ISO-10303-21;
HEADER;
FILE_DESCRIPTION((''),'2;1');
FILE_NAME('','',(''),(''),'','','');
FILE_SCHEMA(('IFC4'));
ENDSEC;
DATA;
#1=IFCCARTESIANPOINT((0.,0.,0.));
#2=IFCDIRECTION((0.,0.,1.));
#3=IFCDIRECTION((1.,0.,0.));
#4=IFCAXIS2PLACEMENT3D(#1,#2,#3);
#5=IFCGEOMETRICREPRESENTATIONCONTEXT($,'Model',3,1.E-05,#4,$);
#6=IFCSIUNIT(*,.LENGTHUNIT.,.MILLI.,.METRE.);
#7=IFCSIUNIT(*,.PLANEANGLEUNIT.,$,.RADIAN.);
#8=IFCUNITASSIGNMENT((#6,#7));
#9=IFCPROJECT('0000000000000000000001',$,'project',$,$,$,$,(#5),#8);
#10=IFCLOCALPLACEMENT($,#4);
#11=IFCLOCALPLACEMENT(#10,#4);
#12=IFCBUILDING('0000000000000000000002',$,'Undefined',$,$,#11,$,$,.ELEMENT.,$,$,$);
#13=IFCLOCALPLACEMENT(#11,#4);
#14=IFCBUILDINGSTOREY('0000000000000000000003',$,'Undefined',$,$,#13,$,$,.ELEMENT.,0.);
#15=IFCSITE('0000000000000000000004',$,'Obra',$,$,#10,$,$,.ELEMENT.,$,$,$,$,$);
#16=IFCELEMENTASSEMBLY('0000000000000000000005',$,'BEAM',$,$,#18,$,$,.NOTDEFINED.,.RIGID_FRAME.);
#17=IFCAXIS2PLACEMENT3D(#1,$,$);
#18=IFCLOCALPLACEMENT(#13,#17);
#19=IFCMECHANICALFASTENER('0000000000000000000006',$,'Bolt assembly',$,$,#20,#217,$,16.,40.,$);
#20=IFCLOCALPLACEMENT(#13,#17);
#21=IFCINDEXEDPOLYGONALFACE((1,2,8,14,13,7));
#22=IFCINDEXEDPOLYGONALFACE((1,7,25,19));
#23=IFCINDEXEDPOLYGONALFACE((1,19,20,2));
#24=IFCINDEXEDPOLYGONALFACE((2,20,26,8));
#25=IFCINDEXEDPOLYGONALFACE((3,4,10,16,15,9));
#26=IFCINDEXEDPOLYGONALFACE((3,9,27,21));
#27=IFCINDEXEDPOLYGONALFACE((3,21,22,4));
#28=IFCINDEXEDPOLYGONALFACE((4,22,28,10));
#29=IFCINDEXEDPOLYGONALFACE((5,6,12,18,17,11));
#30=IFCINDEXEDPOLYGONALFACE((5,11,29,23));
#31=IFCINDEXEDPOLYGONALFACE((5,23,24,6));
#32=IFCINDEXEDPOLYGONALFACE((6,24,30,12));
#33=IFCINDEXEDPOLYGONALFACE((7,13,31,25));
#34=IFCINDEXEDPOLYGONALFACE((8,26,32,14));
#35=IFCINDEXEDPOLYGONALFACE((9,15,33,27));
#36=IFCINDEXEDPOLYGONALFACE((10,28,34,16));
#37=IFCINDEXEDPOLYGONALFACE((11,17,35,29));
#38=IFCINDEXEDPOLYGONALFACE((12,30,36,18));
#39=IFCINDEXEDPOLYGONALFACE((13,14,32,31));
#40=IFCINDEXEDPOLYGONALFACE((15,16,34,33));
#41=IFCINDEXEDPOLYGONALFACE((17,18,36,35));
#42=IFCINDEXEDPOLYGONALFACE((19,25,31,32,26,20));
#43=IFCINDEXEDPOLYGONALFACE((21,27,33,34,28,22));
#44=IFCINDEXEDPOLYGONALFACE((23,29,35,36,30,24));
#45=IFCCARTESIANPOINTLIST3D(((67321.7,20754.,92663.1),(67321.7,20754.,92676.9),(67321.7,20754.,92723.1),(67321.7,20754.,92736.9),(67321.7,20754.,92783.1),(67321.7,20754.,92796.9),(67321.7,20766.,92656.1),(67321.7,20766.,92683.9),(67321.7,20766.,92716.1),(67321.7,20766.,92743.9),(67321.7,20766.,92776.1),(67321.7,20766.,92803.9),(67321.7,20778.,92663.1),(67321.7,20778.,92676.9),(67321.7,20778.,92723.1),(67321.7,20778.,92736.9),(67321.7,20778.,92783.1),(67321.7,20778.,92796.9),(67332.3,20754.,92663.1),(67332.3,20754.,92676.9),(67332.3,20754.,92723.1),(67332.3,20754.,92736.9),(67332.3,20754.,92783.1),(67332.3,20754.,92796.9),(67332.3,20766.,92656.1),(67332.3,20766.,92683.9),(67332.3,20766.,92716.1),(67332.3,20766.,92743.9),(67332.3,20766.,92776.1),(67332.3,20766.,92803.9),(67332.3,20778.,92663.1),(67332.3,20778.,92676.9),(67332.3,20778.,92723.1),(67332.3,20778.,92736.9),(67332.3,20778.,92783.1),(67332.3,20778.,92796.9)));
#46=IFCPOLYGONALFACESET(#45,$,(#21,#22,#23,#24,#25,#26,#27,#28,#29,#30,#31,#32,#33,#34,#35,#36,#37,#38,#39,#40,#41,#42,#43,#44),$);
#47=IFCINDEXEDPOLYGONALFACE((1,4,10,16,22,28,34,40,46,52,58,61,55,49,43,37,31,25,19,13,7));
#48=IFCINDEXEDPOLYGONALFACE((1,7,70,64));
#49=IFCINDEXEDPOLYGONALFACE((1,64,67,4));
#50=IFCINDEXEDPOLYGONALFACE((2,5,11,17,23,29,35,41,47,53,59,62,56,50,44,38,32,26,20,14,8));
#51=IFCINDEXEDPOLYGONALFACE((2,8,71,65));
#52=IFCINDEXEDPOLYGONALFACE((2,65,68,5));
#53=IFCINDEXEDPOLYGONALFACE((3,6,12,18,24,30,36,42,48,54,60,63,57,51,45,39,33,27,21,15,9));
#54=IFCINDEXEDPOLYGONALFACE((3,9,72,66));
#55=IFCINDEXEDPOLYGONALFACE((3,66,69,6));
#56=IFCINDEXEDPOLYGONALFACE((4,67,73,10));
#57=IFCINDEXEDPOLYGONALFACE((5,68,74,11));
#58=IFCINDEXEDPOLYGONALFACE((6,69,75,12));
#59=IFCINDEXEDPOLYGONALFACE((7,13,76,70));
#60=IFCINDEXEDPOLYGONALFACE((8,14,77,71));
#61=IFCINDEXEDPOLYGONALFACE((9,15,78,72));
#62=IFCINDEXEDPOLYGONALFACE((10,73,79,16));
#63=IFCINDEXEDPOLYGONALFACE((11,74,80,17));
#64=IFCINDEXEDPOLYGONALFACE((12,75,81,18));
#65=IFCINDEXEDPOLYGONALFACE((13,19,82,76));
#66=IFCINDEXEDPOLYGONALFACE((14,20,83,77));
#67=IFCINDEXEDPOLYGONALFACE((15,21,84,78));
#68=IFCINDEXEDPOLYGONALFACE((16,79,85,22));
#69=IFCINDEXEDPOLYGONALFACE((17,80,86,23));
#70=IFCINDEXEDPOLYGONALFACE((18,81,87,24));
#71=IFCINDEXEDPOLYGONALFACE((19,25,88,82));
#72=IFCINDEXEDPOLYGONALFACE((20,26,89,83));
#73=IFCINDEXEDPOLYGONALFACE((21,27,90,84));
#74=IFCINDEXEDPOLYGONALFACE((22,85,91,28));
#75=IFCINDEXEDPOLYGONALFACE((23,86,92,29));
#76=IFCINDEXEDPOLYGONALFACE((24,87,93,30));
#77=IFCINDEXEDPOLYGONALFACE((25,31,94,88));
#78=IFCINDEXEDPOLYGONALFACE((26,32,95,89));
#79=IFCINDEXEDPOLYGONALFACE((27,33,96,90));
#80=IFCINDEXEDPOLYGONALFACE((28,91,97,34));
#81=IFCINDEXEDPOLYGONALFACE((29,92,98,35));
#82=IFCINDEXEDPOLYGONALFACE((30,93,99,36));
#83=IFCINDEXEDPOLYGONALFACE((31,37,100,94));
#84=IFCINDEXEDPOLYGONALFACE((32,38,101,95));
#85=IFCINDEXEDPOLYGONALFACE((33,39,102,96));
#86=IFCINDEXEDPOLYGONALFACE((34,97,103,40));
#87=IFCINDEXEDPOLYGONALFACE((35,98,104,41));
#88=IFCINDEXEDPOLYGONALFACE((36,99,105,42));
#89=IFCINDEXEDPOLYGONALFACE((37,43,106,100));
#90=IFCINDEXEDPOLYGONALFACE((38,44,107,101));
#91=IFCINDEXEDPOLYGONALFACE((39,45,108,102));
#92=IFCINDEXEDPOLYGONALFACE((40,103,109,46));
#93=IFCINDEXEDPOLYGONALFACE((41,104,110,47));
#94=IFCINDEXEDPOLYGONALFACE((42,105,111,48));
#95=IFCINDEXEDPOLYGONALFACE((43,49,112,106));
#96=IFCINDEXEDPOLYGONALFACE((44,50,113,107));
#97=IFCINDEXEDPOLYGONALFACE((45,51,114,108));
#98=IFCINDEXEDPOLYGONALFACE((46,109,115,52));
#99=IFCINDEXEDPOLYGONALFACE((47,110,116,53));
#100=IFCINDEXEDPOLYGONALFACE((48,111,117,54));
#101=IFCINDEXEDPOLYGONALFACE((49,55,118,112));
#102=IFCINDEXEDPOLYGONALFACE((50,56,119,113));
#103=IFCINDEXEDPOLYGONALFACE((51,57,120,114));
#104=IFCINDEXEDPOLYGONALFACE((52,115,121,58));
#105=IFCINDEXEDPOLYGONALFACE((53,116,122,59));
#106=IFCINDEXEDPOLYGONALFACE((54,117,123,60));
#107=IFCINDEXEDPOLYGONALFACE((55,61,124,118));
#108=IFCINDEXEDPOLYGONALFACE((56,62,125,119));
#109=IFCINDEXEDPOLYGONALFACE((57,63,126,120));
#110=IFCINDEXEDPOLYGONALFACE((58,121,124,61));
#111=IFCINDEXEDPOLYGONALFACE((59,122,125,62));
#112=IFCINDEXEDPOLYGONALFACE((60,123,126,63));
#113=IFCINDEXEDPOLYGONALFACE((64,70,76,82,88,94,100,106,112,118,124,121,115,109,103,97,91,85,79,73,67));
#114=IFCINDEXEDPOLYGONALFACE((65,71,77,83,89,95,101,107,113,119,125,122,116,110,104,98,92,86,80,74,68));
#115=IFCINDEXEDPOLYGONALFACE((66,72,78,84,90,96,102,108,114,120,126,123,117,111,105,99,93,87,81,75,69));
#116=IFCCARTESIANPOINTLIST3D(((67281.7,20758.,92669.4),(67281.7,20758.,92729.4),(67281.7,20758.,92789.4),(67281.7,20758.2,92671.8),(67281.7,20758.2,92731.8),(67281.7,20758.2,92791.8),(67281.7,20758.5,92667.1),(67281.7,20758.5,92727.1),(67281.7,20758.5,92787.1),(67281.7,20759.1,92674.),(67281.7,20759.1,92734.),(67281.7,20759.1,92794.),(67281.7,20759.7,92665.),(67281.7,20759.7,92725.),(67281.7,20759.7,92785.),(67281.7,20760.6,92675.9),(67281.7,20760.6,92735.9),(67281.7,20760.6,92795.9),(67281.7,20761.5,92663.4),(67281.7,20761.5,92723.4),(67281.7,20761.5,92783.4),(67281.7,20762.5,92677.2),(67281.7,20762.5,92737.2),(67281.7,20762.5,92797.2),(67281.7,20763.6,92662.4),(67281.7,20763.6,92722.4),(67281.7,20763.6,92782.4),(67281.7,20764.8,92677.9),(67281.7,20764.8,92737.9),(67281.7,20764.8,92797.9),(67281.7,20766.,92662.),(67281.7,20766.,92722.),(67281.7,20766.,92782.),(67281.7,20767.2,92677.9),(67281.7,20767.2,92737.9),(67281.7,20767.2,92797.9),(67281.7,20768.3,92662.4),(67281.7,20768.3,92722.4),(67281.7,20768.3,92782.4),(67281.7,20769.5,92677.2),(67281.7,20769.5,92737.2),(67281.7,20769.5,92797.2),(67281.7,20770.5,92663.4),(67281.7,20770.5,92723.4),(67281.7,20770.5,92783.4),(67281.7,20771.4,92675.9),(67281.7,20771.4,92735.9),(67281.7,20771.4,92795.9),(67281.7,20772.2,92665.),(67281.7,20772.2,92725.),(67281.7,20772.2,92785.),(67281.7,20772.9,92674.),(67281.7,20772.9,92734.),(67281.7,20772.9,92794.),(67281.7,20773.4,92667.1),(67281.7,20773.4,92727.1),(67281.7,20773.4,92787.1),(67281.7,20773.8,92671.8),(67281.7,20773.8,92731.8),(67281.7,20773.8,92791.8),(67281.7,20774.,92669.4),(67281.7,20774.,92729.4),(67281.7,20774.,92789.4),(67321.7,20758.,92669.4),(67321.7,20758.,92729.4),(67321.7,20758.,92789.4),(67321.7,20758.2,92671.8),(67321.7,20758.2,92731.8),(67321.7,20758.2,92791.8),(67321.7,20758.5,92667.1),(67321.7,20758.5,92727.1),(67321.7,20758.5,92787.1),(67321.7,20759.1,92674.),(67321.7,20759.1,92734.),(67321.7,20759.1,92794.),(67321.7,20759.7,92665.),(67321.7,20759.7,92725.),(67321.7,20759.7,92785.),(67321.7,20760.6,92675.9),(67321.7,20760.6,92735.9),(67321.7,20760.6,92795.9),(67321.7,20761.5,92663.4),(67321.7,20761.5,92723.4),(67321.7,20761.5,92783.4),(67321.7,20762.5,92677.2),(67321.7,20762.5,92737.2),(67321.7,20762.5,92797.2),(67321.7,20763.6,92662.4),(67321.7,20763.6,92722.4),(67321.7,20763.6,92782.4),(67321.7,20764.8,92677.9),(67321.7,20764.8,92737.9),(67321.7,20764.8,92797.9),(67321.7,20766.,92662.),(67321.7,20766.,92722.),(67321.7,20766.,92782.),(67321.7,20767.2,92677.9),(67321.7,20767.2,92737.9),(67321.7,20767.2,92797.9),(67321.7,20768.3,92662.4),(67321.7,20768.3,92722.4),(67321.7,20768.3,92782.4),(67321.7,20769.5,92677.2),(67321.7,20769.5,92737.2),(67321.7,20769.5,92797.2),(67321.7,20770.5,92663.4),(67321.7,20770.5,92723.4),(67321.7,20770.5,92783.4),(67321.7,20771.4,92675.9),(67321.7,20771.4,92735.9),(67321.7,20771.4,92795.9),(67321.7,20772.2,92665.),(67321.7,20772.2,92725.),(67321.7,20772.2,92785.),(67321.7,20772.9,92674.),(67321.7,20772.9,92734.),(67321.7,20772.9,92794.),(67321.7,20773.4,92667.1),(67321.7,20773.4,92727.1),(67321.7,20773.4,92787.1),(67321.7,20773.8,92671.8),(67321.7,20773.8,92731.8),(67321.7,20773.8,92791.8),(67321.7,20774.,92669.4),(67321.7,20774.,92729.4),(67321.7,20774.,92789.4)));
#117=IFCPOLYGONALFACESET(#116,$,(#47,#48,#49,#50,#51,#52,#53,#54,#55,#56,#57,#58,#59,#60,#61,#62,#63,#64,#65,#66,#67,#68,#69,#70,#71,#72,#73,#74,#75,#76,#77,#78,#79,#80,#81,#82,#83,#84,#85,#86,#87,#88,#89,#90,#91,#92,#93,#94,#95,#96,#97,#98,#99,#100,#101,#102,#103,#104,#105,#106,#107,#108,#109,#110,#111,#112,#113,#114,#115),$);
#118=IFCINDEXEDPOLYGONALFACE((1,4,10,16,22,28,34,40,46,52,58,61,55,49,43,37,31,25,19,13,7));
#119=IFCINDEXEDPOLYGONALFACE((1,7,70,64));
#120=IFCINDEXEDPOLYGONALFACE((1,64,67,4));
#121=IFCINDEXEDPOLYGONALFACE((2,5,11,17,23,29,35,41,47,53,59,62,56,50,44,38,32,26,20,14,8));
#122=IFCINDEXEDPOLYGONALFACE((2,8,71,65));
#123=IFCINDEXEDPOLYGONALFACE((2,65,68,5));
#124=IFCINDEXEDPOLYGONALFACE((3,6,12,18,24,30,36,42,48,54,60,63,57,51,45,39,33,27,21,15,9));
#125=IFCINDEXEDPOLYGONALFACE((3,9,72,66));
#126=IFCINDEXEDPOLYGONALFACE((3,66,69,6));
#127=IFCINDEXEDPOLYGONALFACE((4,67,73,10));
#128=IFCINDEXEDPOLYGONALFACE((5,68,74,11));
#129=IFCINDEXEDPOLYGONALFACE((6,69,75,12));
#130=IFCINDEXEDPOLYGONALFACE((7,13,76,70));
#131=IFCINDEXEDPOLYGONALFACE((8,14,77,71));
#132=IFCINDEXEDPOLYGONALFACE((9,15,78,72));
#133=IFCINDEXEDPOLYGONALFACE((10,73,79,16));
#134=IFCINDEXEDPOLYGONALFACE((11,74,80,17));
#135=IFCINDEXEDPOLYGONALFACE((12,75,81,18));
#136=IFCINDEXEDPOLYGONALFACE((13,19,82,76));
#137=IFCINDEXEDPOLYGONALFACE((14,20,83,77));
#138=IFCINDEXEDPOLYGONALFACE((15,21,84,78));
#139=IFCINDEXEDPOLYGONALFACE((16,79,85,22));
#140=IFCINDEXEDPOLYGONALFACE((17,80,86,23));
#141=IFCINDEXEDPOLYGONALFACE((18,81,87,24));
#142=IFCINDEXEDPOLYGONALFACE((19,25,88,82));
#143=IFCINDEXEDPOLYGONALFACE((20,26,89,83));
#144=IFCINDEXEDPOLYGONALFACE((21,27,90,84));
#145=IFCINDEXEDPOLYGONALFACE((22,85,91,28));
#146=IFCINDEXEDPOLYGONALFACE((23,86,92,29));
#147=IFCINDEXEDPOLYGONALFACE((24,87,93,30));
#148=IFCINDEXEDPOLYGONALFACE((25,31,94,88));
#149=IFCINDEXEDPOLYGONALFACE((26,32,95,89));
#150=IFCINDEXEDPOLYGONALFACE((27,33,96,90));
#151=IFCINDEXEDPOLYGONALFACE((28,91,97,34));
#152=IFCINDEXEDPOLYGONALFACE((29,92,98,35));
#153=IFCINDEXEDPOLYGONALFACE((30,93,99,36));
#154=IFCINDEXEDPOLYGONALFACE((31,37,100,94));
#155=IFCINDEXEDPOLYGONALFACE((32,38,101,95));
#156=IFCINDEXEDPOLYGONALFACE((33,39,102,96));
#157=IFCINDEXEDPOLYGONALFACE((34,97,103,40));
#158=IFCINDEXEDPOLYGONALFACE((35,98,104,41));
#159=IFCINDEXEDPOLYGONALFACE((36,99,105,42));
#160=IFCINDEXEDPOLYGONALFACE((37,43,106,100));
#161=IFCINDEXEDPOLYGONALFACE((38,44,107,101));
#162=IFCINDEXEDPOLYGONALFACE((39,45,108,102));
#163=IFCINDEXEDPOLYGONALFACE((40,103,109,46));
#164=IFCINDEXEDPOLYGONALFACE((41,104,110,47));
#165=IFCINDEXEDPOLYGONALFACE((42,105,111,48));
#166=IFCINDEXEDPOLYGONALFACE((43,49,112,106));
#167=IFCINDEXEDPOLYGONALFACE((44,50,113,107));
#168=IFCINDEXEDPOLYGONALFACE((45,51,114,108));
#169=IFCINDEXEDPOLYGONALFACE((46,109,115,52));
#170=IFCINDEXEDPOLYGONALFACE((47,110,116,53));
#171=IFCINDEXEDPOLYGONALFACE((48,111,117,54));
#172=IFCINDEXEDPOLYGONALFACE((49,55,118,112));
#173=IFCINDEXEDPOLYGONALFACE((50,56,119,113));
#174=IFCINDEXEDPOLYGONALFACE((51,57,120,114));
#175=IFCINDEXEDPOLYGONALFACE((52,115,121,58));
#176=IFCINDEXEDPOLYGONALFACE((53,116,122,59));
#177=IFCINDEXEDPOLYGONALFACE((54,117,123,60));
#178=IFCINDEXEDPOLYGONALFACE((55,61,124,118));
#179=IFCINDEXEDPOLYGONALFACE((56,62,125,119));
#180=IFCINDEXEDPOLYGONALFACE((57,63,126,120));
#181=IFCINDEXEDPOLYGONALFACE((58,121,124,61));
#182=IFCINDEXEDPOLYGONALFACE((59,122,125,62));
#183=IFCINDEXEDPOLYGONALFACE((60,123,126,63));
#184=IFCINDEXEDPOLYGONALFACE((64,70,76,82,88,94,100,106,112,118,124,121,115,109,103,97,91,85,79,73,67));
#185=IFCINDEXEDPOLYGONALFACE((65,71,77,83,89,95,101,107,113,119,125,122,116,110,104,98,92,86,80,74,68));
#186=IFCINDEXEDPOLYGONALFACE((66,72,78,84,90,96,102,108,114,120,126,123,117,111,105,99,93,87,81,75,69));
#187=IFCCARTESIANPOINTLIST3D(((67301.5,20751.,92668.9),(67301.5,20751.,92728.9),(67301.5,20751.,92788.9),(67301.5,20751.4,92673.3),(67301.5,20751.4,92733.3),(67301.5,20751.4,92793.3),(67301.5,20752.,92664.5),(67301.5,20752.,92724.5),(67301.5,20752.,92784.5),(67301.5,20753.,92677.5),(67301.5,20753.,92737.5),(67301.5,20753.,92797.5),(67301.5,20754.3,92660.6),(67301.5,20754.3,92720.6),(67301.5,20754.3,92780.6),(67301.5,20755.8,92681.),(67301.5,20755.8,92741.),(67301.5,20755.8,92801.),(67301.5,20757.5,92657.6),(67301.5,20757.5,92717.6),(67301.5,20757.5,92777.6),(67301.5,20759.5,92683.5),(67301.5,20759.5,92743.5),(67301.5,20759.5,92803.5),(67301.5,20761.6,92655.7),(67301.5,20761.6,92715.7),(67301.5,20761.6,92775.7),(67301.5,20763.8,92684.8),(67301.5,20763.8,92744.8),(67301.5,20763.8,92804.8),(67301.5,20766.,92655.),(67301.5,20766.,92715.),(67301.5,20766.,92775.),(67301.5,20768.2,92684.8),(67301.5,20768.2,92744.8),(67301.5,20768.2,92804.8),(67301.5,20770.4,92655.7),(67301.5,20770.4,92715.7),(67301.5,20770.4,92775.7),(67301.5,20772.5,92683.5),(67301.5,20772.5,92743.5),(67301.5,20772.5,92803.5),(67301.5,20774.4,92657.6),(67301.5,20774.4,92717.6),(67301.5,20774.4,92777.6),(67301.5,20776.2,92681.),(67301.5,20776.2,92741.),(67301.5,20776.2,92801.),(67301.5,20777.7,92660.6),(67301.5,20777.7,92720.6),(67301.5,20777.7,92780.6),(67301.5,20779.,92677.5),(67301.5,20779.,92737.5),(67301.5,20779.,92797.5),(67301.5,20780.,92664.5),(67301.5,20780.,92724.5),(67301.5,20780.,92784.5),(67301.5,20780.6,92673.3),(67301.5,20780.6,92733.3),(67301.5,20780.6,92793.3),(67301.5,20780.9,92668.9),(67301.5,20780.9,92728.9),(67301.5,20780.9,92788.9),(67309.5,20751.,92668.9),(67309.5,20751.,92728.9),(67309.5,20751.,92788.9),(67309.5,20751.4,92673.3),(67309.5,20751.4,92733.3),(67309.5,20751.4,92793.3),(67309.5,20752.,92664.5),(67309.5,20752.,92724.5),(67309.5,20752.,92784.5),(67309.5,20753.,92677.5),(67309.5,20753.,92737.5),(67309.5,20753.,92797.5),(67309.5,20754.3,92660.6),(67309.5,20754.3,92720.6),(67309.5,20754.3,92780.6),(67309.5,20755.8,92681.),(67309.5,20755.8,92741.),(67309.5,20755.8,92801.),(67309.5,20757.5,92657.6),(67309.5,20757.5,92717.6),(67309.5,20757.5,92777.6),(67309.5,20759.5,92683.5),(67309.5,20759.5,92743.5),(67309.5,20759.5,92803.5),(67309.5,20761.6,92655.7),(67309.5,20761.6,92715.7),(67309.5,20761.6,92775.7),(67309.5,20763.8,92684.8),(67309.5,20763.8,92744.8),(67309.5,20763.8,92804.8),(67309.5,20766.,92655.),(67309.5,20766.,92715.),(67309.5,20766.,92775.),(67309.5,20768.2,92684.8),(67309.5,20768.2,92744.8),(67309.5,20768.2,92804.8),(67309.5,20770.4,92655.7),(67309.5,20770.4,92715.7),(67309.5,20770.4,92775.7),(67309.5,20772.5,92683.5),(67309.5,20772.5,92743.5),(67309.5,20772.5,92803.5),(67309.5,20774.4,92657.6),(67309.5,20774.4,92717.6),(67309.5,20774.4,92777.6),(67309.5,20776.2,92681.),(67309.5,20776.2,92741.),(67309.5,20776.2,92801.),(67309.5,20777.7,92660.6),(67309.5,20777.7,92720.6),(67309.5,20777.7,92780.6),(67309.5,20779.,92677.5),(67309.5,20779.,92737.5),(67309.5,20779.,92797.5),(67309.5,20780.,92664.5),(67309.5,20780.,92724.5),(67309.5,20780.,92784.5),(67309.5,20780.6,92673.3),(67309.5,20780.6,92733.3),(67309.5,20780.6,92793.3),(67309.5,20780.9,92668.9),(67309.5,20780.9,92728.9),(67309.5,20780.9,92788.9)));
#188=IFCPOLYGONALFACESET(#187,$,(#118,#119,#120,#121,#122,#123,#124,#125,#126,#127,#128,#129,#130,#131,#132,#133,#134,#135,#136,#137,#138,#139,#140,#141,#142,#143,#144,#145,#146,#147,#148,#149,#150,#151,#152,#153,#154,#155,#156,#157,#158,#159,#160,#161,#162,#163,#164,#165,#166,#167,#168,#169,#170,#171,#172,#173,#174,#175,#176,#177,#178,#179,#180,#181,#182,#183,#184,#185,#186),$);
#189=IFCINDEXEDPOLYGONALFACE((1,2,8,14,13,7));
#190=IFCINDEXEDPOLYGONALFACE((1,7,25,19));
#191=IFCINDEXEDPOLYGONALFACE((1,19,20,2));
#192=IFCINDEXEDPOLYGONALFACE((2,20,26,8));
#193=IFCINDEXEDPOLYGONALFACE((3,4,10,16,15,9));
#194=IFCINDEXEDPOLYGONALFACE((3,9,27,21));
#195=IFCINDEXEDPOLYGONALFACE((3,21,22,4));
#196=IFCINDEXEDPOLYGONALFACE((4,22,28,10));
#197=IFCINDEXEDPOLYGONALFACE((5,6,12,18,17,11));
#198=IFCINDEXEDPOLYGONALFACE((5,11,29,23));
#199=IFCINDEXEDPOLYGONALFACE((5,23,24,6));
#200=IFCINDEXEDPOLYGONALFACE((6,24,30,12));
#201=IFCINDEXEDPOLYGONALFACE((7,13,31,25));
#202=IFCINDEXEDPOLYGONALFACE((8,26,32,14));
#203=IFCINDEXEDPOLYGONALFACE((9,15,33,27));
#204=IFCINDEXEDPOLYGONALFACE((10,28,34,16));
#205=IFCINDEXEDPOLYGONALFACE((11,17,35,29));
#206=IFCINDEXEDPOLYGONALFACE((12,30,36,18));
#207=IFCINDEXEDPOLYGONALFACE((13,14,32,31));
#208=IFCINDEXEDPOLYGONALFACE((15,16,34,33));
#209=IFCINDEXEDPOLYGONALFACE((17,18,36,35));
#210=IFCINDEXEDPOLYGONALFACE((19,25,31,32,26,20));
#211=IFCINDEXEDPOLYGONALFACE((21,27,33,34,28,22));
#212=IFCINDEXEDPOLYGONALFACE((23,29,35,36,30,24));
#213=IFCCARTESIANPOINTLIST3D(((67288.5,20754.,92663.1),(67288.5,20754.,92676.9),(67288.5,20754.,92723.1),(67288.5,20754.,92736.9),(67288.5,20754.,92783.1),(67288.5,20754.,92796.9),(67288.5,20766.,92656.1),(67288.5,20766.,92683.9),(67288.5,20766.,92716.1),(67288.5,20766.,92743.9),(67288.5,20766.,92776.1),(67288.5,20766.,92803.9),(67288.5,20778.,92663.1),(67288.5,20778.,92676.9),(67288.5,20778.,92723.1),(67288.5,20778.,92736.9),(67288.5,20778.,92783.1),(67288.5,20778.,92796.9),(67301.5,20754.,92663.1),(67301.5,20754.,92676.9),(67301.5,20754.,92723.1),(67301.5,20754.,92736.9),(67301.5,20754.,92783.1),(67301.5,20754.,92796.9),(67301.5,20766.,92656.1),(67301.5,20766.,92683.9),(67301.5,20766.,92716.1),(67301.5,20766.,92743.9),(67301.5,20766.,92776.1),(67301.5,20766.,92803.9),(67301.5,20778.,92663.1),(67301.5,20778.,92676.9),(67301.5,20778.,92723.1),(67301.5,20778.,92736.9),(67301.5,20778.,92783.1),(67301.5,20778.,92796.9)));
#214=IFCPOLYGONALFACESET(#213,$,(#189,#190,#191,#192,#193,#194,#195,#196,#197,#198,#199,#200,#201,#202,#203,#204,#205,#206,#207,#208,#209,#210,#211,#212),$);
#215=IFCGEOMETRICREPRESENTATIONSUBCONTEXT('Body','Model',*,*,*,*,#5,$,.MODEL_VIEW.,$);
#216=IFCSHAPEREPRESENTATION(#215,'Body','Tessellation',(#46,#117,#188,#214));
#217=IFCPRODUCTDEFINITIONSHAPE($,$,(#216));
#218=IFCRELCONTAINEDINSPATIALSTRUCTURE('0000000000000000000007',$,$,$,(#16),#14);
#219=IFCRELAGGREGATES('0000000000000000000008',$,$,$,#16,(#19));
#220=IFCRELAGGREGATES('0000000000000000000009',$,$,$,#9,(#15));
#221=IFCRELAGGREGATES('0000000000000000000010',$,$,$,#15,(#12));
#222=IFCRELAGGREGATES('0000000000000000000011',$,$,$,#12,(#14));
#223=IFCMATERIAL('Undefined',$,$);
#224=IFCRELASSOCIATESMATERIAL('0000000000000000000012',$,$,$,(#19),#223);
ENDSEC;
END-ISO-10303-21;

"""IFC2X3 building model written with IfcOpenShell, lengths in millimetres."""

from ifc_helpers import new_model, si_unit, frame, origin_with_axes, origin_2d_with_axis, place, context, subcontext, project, spatial, polyline, circle, outline, extrude, source, transform, mapped, material, element, aggregate, save


model = new_model("IFC2X3")

# Units and contexts
model_context = context("Model", 3, precision=1e-05, world=origin_with_axes())
body_context = subcontext(model_context, "Body", "Model", "MODEL_VIEW")
ifc_project = project(units=[si_unit("LENGTHUNIT", "METRE", prefix="MILLI"), si_unit("PLANEANGLEUNIT", "RADIAN")], contexts=[model_context])

# Site, building, storey
site_placement = place(None, origin_with_axes())
site = spatial("IfcSite", under=ifc_project, at=site_placement, Name="Obra", CompositionType="ELEMENT")
building_placement = place(site_placement, origin_with_axes())
building = spatial("IfcBuilding", under=site, at=building_placement, Name="Undefined", CompositionType="ELEMENT")
storey_placement = place(building_placement, origin_with_axes())
storey = spatial("IfcBuildingStorey", under=building, at=storey_placement, Name="Undefined", CompositionType="ELEMENT", Elevation=0.0)

# Shared definitions
ifc_material_1 = material(Name="Undefined")

# Element assembly, mechanical fastener
shared_shape_1 = source(origin_with_axes(), body_context, "Body", "SweptSolid", [
    extrude(outline(polyline([(13.9, 0.0), (6.9, 12.0), (-6.9, 12.0), (-13.9, 0.0), (-6.9, -12.0), (6.9, -12.0), (13.9, 0.0)])), frame((0.0, -19.7, 0.0), z_axis=(0.0, 1.0, 0.0), x_axis=(1.0, 0.0, 0.0)), (0.0, 0.0, 1.0), 10.6),
    extrude(circle(Radius=8.0, at=origin_2d_with_axis()), frame((0.0, -9.1, 0.0), z_axis=(0.0, 1.0, 0.0), x_axis=(1.0, 0.0, 0.0)), (0.0, 0.0, 1.0), 40.0),
    extrude(circle(Radius=15.0, at=origin_2d_with_axis()), frame((0.0, 3.1, 0.0), z_axis=(0.0, 1.0, 0.0), x_axis=(1.0, 0.0, 0.0)), (0.0, 0.0, 1.0), 8.0),
    extrude(outline(polyline([(13.9, 0.0), (6.9, 12.0), (-6.9, 12.0), (-13.9, 0.0), (-6.9, -12.0), (6.9, -12.0), (13.9, 0.0)])), frame((0.0, 11.1, 0.0), z_axis=(0.0, 1.0, 0.0), x_axis=(1.0, 0.0, 0.0)), (0.0, 0.0, 1.0), 13.0),
])
assembly_1_placement = place(storey_placement, origin_with_axes())
assembly_1 = element("IfcElementAssembly", 1, at=assembly_1_placement, inside=storey, Name="BEAM", AssemblyPlace="NOTDEFINED", PredefinedType="RIGID_FRAME")
mechanical_fastener_1_placement = place(assembly_1_placement, frame((67312.6, 20716.0, 92850.0), z_axis=(-0.000002, 1.0, 0.0), x_axis=(0.0, 0.0, -1.0)))
mechanical_fastener_1 = element("IfcMechanicalFastener", 2, at=mechanical_fastener_1_placement, material=ifc_material_1, Name="Bolt assembly", NominalDiameter=16.0, NominalLength=40.0, context=body_context, shape_type="MappedRepresentation", body=[
    mapped(shared_shape_1, transform((60.0, 0.0, 50.0))),
    mapped(shared_shape_1, transform((120.0, 0.0, 50.0))),
    mapped(shared_shape_1, transform((180.0, 0.0, 50.0))),
])

aggregate(assembly_1, [mechanical_fastener_1])

save(model, "model.ifc")
